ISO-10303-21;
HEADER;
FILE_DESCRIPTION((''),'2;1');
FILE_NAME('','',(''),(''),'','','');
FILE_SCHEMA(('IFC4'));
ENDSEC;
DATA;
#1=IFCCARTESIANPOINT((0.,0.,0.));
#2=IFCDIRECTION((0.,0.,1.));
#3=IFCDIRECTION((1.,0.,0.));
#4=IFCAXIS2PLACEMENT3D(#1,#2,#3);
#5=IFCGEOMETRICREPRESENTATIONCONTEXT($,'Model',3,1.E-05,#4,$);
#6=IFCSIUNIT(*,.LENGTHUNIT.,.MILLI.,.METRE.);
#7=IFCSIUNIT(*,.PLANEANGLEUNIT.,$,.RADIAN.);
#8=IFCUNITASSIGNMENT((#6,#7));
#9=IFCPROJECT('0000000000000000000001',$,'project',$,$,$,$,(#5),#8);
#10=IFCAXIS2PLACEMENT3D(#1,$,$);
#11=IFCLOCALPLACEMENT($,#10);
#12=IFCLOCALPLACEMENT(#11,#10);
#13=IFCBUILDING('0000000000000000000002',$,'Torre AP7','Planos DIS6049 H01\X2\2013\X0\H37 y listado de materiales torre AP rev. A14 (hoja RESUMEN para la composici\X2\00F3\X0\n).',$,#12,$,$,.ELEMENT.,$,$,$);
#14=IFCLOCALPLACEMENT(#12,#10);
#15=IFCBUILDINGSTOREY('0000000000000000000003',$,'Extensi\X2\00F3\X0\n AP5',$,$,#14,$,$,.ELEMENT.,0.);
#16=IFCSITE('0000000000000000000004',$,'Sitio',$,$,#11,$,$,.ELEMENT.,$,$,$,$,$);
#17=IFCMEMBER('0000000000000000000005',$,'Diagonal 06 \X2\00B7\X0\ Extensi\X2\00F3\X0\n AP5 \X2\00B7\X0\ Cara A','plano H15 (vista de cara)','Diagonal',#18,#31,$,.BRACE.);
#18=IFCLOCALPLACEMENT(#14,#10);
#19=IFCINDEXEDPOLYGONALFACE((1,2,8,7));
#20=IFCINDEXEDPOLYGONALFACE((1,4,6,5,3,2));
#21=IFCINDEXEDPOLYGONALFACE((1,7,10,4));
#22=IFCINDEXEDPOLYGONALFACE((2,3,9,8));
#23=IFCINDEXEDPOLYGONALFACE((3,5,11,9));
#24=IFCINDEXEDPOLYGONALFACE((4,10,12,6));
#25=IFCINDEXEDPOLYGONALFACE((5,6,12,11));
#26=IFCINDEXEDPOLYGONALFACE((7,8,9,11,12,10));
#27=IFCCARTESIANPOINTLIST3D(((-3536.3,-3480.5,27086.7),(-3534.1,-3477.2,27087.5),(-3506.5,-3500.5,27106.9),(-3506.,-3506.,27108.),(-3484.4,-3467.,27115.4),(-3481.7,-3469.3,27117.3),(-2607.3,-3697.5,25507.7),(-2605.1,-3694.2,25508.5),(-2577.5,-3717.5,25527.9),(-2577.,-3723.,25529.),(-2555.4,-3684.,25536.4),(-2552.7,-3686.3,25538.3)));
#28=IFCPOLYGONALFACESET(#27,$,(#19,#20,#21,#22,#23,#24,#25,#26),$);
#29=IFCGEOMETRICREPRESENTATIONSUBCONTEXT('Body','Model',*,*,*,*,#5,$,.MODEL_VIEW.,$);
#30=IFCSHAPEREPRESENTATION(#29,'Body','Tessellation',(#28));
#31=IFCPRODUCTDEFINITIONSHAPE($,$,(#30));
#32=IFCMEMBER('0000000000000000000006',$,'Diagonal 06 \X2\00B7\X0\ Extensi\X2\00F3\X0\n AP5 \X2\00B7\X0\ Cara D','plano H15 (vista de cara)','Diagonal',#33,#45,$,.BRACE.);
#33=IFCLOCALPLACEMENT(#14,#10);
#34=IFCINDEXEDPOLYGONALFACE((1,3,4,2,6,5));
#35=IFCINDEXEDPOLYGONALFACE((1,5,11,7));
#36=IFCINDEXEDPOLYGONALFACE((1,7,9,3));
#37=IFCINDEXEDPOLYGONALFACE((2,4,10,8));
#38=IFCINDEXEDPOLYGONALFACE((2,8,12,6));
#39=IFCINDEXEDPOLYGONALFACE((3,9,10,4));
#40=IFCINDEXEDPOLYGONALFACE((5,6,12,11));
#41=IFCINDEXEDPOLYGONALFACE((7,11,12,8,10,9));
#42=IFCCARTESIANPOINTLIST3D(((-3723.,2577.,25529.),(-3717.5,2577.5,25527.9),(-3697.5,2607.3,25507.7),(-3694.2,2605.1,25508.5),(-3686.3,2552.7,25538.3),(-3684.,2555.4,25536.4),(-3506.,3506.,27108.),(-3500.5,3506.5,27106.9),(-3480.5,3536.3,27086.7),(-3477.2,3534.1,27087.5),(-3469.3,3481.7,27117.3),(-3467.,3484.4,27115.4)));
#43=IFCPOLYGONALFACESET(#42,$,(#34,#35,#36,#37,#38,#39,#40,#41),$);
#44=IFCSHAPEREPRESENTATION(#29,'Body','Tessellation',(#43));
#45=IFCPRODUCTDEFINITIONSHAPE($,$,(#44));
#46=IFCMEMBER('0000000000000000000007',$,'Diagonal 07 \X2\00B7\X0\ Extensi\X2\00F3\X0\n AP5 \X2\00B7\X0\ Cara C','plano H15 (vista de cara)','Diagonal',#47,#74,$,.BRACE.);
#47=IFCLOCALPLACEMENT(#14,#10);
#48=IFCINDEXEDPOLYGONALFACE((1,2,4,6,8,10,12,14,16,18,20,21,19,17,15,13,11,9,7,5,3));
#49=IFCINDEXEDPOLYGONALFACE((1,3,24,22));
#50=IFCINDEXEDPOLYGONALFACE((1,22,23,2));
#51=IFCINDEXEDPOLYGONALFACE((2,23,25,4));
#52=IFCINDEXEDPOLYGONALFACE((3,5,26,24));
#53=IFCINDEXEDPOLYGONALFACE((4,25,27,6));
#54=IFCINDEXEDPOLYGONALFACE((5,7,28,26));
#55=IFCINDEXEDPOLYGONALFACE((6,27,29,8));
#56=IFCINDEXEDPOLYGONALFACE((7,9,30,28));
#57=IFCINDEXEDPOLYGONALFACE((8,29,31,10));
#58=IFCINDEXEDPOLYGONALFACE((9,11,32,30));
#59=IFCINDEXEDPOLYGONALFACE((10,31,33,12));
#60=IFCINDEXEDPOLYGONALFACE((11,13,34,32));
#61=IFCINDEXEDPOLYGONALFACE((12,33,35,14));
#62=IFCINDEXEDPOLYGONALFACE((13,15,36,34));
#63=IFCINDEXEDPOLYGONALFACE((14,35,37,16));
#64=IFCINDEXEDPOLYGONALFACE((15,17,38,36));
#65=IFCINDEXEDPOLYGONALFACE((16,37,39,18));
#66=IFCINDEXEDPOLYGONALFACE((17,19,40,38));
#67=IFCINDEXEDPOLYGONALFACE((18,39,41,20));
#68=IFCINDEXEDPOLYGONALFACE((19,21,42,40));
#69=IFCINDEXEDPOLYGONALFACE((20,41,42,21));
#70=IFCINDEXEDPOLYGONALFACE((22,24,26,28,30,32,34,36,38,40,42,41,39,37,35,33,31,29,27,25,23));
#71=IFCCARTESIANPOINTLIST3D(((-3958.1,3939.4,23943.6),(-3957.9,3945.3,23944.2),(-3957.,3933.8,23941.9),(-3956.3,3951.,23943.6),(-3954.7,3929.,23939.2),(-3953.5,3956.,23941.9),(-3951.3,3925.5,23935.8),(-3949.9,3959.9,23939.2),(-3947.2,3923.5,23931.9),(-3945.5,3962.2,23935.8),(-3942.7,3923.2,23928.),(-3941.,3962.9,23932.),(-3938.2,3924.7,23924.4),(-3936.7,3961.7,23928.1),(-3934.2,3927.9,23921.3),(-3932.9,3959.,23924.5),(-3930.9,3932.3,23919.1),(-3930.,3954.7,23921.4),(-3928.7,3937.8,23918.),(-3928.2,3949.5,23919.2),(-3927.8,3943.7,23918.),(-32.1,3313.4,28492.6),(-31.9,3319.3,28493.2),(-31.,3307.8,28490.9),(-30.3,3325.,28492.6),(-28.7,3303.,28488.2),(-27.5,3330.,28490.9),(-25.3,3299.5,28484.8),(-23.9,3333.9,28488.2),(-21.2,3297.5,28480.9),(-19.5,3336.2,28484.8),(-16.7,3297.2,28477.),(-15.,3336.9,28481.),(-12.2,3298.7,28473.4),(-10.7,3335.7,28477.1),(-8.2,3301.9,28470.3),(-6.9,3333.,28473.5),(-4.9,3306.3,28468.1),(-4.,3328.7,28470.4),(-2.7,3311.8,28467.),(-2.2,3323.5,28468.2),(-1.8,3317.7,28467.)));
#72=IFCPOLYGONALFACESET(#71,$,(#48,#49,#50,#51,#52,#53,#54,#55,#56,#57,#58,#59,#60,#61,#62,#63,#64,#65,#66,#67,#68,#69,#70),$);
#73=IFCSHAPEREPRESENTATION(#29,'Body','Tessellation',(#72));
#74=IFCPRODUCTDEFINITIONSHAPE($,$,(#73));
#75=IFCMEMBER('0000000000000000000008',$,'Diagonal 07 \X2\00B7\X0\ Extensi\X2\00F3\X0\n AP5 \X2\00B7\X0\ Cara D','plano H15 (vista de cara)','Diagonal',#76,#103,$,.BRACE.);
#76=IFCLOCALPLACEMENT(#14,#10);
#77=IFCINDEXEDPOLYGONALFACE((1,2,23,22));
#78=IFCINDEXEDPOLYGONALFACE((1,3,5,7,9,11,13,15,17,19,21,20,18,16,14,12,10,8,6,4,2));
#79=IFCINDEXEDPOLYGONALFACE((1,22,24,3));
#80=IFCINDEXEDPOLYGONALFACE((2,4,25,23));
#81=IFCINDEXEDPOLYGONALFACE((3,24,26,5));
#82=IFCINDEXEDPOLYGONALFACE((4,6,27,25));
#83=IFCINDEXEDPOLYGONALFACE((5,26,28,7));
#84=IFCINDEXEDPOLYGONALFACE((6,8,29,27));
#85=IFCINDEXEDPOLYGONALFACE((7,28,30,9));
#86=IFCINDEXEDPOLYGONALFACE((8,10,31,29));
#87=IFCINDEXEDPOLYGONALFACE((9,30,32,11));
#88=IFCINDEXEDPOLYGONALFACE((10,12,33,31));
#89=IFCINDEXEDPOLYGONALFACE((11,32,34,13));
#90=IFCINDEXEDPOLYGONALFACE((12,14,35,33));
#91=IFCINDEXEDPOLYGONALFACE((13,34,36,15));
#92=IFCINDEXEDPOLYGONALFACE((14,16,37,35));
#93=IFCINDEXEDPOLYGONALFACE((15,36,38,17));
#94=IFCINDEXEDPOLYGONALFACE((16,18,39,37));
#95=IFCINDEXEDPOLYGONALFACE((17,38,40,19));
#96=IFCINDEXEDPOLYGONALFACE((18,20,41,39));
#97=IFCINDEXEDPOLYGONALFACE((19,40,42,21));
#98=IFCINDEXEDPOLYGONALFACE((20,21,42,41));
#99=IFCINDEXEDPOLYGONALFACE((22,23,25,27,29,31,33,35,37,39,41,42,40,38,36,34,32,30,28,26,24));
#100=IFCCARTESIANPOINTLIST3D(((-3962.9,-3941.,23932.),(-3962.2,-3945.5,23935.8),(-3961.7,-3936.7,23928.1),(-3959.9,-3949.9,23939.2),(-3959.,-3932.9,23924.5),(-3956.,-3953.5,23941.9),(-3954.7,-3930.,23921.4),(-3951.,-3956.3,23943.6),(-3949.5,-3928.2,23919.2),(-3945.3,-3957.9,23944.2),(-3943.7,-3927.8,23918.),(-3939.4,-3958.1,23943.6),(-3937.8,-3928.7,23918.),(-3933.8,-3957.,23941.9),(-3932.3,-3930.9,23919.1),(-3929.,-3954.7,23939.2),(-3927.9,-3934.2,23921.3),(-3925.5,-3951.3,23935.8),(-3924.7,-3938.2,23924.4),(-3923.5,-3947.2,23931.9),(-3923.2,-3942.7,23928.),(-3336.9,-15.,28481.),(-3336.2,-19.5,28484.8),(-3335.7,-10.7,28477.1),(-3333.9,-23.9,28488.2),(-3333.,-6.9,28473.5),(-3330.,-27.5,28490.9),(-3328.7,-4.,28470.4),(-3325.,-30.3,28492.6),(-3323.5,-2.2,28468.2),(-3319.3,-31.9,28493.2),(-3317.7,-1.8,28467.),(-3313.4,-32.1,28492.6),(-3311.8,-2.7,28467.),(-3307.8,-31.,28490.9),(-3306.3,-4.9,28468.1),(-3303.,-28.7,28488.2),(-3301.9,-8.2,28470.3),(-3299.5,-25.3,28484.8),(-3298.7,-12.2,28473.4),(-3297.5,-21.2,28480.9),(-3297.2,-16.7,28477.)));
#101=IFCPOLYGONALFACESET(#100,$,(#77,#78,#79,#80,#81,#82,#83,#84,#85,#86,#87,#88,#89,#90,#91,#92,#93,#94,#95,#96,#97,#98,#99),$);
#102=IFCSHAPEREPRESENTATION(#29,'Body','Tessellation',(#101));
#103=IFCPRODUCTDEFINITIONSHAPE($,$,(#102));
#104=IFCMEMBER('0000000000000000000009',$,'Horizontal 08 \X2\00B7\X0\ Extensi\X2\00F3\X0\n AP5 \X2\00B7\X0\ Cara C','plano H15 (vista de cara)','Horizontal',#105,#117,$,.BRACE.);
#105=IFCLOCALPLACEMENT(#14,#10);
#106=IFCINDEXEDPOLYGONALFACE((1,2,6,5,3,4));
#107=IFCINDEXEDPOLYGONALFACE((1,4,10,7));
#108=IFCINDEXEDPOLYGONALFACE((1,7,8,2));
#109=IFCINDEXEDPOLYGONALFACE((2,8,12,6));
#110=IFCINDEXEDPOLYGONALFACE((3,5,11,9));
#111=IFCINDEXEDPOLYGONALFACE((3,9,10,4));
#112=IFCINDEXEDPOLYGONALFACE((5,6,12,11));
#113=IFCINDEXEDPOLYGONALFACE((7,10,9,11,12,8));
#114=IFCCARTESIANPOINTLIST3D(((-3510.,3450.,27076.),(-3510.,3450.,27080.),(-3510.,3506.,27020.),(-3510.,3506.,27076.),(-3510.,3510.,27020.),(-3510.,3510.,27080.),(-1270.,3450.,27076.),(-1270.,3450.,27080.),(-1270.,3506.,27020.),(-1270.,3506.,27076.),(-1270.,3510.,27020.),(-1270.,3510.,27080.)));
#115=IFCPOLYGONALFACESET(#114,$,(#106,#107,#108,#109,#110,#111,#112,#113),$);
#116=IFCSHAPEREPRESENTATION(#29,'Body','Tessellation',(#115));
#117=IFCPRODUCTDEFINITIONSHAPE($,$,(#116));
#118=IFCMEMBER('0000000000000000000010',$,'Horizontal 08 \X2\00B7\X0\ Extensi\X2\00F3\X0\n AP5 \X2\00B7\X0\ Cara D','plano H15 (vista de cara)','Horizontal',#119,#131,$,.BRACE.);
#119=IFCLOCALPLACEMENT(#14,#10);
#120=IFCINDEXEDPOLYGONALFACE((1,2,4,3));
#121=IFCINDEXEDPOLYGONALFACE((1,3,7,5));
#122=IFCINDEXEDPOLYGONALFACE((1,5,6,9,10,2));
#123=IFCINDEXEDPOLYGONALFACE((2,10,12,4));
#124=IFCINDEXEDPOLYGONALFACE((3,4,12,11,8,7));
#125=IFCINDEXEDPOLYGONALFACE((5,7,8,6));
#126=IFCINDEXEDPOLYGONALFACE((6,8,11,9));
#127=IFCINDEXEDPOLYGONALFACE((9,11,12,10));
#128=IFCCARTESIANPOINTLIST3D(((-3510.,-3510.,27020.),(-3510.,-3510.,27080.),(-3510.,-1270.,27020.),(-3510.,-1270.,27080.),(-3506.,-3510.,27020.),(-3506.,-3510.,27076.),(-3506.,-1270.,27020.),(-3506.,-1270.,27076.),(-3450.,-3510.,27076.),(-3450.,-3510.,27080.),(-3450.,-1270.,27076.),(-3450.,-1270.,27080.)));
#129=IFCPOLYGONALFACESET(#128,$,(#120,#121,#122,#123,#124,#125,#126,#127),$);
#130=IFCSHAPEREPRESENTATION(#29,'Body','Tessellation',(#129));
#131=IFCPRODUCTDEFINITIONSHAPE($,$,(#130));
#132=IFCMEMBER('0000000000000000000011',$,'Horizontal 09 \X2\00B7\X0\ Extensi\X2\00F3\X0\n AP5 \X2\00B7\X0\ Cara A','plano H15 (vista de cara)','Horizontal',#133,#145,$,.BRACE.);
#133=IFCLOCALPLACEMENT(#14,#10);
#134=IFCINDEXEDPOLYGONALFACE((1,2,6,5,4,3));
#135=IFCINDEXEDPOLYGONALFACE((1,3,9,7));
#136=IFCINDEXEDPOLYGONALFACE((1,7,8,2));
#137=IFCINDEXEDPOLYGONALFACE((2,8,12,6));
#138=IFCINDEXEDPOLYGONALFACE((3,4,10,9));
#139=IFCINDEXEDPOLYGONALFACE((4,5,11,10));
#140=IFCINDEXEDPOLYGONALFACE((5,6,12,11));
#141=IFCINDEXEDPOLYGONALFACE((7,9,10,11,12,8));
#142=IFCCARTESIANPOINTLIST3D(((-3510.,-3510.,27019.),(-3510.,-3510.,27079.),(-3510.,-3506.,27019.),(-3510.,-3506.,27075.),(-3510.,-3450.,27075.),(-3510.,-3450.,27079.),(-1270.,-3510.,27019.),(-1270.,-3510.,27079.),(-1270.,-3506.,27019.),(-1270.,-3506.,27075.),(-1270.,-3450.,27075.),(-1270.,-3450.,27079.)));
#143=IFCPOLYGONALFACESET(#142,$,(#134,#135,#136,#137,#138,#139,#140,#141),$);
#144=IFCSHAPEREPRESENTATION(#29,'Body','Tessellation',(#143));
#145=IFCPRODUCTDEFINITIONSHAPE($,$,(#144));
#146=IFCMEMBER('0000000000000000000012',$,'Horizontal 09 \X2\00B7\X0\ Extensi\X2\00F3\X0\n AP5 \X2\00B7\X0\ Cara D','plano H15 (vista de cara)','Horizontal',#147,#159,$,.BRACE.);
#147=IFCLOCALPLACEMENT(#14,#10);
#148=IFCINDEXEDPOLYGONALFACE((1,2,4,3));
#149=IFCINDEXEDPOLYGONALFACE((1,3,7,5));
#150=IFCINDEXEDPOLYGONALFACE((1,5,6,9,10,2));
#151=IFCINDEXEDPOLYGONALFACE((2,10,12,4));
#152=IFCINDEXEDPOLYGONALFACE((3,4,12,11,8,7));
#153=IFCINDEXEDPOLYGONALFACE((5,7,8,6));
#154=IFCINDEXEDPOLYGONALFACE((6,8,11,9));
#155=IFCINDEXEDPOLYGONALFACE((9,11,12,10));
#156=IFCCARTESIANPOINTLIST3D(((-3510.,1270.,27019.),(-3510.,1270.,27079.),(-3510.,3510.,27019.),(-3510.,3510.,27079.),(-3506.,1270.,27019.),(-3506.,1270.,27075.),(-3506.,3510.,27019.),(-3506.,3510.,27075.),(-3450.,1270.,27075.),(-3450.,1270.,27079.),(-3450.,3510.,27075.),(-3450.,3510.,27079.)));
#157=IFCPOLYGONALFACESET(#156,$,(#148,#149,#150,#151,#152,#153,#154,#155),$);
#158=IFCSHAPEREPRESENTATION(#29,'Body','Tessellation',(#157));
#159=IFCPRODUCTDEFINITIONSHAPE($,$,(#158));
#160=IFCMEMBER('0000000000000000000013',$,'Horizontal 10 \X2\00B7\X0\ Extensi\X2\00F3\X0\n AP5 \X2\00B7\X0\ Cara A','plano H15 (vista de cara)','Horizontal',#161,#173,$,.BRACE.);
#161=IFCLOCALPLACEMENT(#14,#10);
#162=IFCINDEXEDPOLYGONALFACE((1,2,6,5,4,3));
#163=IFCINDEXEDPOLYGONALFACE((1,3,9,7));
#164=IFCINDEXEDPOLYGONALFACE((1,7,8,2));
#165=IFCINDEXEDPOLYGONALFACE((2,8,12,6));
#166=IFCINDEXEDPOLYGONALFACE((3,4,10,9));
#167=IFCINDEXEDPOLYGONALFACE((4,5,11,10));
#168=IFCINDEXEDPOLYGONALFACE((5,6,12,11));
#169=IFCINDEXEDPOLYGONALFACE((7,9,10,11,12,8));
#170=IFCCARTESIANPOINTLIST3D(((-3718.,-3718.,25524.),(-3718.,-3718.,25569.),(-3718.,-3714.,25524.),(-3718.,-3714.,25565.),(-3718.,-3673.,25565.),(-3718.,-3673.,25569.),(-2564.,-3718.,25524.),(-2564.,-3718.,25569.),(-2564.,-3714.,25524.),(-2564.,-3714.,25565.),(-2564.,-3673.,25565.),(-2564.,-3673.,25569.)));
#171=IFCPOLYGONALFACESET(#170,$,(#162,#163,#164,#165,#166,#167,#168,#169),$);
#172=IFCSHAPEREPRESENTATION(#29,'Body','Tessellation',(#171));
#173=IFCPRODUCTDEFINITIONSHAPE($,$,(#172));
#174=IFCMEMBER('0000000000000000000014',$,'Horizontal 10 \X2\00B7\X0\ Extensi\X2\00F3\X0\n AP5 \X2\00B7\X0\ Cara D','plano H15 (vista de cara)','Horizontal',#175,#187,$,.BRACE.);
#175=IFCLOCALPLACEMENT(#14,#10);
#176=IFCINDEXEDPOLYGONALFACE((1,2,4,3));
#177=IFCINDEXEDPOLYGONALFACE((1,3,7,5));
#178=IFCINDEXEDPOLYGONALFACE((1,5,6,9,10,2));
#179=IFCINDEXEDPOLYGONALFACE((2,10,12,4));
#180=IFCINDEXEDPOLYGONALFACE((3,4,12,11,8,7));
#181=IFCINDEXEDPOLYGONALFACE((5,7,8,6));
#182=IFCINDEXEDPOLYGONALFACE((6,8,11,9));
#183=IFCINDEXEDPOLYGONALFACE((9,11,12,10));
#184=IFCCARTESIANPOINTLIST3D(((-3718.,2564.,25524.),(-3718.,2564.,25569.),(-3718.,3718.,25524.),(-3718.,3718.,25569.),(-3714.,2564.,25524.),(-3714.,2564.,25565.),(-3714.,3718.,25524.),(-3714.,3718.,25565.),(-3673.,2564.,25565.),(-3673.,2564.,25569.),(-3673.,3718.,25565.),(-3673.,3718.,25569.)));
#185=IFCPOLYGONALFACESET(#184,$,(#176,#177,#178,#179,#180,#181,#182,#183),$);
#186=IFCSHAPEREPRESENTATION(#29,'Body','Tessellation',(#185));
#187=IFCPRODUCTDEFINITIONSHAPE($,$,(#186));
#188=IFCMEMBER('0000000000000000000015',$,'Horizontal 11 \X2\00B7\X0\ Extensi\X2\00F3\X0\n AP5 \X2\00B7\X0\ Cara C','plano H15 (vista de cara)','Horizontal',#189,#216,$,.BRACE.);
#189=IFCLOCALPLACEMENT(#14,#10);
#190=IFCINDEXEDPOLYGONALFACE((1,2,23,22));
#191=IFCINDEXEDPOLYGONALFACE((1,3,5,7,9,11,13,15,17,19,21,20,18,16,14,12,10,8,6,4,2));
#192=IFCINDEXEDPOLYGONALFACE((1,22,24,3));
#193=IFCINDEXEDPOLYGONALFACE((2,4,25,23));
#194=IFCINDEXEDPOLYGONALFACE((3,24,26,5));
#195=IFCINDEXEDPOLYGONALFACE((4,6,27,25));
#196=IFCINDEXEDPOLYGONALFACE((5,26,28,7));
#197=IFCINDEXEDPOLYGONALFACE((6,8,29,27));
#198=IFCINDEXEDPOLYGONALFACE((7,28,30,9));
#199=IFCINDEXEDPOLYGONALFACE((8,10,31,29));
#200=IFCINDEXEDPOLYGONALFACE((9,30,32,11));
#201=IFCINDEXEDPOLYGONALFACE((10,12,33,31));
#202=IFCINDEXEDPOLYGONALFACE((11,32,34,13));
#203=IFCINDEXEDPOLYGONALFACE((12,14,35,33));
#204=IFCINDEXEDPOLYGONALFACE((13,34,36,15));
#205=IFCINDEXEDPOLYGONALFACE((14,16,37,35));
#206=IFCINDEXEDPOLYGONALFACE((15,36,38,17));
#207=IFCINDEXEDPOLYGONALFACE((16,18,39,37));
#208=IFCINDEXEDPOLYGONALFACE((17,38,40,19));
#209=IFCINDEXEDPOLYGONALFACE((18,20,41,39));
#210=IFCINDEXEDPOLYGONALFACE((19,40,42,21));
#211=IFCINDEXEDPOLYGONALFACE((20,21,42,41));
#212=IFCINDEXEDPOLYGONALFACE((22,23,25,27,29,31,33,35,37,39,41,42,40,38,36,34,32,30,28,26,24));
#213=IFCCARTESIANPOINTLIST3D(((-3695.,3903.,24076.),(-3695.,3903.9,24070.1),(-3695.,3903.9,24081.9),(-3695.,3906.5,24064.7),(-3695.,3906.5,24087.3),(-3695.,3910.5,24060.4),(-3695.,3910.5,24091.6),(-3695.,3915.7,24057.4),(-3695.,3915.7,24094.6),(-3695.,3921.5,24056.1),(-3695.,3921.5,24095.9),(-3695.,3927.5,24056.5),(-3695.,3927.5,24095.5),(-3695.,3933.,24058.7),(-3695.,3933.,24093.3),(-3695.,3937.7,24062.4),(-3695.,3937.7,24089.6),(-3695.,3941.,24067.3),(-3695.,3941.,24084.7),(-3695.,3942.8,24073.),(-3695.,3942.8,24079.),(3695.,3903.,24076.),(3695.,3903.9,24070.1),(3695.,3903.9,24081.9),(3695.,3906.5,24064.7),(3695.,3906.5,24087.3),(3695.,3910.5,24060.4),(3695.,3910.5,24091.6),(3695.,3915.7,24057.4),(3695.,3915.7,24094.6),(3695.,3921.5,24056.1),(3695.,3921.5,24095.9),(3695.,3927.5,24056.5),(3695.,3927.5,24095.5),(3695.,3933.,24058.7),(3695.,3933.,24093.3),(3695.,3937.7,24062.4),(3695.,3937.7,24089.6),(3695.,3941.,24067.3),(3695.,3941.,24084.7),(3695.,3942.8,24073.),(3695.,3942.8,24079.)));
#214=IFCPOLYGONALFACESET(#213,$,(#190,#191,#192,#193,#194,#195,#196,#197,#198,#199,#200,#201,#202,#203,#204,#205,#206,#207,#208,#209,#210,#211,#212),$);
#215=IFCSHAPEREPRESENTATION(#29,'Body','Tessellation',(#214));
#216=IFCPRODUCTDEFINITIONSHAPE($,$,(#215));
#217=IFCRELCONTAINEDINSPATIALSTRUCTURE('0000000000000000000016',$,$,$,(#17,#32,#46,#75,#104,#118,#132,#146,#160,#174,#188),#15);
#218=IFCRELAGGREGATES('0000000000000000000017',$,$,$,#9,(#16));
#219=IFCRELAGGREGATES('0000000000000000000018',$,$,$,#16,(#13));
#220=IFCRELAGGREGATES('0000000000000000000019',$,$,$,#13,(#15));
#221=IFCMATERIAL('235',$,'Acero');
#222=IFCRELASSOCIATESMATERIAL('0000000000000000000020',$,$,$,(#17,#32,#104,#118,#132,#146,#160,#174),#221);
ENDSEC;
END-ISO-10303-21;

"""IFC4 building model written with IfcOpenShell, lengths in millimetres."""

from ifc_helpers import new_model, si_unit, frame, frame_2d, origin, origin_with_axes, place, context, subcontext, project, spatial, circle, l_section, extrude, material, element, save


model = new_model("IFC4")

# Units and contexts
model_context = context("Model", 3, precision=1e-05, world=origin_with_axes())
body_context = subcontext(model_context, "Body", "Model", "MODEL_VIEW")
ifc_project = project(units=[si_unit("LENGTHUNIT", "METRE", prefix="MILLI"), si_unit("PLANEANGLEUNIT", "RADIAN")], contexts=[model_context])

# Site, building, storey
site_placement = place(None, origin())
site = spatial("IfcSite", under=ifc_project, at=site_placement, Name="Sitio", CompositionType="ELEMENT")
building_placement = place(site_placement, origin())
building = spatial("IfcBuilding", under=site, at=building_placement, Name="Torre AP7", Description="Planos DIS6049 H01–H37 y listado de materiales torre AP rev. A14 (hoja RESUMEN para la composición).", CompositionType="ELEMENT")
storey_placement = place(building_placement, origin())
storey = spatial("IfcBuildingStorey", under=building, at=storey_placement, Name="Extensión AP5", CompositionType="ELEMENT", Elevation=0.0)

# Members
ifc_material_1 = material(Name="235", Category="Acero")
for number, where, z_axis, x_axis, name in (
    (1, (-2577.0, -3723.0, 25529.0), (-0.503571, 0.117626, 0.855909), (0.540952, 0.815383, 0.20621), "Diagonal 06 · Extensión AP5 · Cara A"),
    (2, (-3723.0, 2577.0, 25529.0), (0.117626, 0.503571, 0.855909), (0.815383, -0.540952, 0.20621), "Diagonal 06 · Extensión AP5 · Cara D"),
):
    element("IfcMember", number, at=place(storey_placement, frame(where, z_axis=z_axis, x_axis=x_axis)), inside=storey, material=ifc_material_1, Name=name, Description="plano H15 (vista de cara)", ObjectType="Diagonal", PredefinedType="BRACE", context=body_context, shape_type="SweptSolid", body=[
        extrude(l_section(Depth=45.0, Width=45.0, Thickness=4.0, at=frame_2d((22.5, 22.5))), None, (0.0, 0.0, 1.0), 1844.8),
    ])
for number, where, z_axis, x_axis, name in (
    (3, (-3943.0, 3943.0, 23931.0), (0.649847, -0.103618, 0.752969), (0.237576, -0.913334, -0.330725), "Diagonal 07 · Extensión AP5 · Cara C"),
    (4, (-3943.0, -3943.0, 23931.0), (0.103618, 0.649847, 0.752969), (0.913334, 0.237576, -0.330725), "Diagonal 07 · Extensión AP5 · Cara D"),
):
    element("IfcMember", number, at=place(storey_placement, frame(where, z_axis=z_axis, x_axis=x_axis)), inside=storey, Name=name, Description="plano H15 (vista de cara)", ObjectType="Diagonal", PredefinedType="BRACE", context=body_context, shape_type="SweptSolid", body=[
        extrude(circle(Radius=20.0), None, (0.0, 0.0, 1.0), 6041.4),
    ])
for number, where, z_axis, x_axis, name in (
    (5, (-3510.0, 3510.0, 27080.0), (1.0, 0.0, 0.0), (0.0, -1.0, 0.0), "Horizontal 08 · Extensión AP5 · Cara C"),
    (6, (-3510.0, -3510.0, 27080.0), (0.0, 1.0, 0.0), (1.0, 0.0, 0.0), "Horizontal 08 · Extensión AP5 · Cara D"),
    (7, (-1270.0, -3510.0, 27079.0), (-1.0, 0.0, 0.0), (0.0, 1.0, 0.0), "Horizontal 09 · Extensión AP5 · Cara A"),
    (8, (-3510.0, 1270.0, 27079.0), (0.0, 1.0, 0.0), (1.0, 0.0, 0.0), "Horizontal 09 · Extensión AP5 · Cara D"),
):
    element("IfcMember", number, at=place(storey_placement, frame(where, z_axis=z_axis, x_axis=x_axis)), inside=storey, material=ifc_material_1, Name=name, Description="plano H15 (vista de cara)", ObjectType="Horizontal", PredefinedType="BRACE", context=body_context, shape_type="SweptSolid", body=[
        extrude(l_section(Depth=60.0, Width=60.0, Thickness=4.0, at=frame_2d((30.0, 30.0))), None, (0.0, 0.0, 1.0), 2240.0),
    ])
for number, where, z_axis, x_axis, name in (
    (9, (-2564.0, -3718.0, 25569.0), (-1.0, 0.0, 0.0), (0.0, 1.0, 0.0), "Horizontal 10 · Extensión AP5 · Cara A"),
    (10, (-3718.0, 2564.0, 25569.0), (0.0, 1.0, 0.0), (1.0, 0.0, 0.0), "Horizontal 10 · Extensión AP5 · Cara D"),
):
    element("IfcMember", number, at=place(storey_placement, frame(where, z_axis=z_axis, x_axis=x_axis)), inside=storey, material=ifc_material_1, Name=name, Description="plano H15 (vista de cara)", ObjectType="Horizontal", PredefinedType="BRACE", context=body_context, shape_type="SweptSolid", body=[
        extrude(l_section(Depth=45.0, Width=45.0, Thickness=4.0, at=frame_2d((22.5, 22.5))), None, (0.0, 0.0, 1.0), 1154.0),
    ])
for number, where, z_axis, x_axis, name in (
    (11, (-3695.0, 3923.0, 24076.0), (1.0, 0.0, 0.0), (0.0, -1.0, 0.0), "Horizontal 11 · Extensión AP5 · Cara C"),
):
    element("IfcMember", number, at=place(storey_placement, frame(where, z_axis=z_axis, x_axis=x_axis)), inside=storey, Name=name, Description="plano H15 (vista de cara)", ObjectType="Horizontal", PredefinedType="BRACE", context=body_context, shape_type="SweptSolid", body=[
        extrude(circle(Radius=20.0), None, (0.0, 0.0, 1.0), 7390.0),
    ])

save(model, "model.ifc")
